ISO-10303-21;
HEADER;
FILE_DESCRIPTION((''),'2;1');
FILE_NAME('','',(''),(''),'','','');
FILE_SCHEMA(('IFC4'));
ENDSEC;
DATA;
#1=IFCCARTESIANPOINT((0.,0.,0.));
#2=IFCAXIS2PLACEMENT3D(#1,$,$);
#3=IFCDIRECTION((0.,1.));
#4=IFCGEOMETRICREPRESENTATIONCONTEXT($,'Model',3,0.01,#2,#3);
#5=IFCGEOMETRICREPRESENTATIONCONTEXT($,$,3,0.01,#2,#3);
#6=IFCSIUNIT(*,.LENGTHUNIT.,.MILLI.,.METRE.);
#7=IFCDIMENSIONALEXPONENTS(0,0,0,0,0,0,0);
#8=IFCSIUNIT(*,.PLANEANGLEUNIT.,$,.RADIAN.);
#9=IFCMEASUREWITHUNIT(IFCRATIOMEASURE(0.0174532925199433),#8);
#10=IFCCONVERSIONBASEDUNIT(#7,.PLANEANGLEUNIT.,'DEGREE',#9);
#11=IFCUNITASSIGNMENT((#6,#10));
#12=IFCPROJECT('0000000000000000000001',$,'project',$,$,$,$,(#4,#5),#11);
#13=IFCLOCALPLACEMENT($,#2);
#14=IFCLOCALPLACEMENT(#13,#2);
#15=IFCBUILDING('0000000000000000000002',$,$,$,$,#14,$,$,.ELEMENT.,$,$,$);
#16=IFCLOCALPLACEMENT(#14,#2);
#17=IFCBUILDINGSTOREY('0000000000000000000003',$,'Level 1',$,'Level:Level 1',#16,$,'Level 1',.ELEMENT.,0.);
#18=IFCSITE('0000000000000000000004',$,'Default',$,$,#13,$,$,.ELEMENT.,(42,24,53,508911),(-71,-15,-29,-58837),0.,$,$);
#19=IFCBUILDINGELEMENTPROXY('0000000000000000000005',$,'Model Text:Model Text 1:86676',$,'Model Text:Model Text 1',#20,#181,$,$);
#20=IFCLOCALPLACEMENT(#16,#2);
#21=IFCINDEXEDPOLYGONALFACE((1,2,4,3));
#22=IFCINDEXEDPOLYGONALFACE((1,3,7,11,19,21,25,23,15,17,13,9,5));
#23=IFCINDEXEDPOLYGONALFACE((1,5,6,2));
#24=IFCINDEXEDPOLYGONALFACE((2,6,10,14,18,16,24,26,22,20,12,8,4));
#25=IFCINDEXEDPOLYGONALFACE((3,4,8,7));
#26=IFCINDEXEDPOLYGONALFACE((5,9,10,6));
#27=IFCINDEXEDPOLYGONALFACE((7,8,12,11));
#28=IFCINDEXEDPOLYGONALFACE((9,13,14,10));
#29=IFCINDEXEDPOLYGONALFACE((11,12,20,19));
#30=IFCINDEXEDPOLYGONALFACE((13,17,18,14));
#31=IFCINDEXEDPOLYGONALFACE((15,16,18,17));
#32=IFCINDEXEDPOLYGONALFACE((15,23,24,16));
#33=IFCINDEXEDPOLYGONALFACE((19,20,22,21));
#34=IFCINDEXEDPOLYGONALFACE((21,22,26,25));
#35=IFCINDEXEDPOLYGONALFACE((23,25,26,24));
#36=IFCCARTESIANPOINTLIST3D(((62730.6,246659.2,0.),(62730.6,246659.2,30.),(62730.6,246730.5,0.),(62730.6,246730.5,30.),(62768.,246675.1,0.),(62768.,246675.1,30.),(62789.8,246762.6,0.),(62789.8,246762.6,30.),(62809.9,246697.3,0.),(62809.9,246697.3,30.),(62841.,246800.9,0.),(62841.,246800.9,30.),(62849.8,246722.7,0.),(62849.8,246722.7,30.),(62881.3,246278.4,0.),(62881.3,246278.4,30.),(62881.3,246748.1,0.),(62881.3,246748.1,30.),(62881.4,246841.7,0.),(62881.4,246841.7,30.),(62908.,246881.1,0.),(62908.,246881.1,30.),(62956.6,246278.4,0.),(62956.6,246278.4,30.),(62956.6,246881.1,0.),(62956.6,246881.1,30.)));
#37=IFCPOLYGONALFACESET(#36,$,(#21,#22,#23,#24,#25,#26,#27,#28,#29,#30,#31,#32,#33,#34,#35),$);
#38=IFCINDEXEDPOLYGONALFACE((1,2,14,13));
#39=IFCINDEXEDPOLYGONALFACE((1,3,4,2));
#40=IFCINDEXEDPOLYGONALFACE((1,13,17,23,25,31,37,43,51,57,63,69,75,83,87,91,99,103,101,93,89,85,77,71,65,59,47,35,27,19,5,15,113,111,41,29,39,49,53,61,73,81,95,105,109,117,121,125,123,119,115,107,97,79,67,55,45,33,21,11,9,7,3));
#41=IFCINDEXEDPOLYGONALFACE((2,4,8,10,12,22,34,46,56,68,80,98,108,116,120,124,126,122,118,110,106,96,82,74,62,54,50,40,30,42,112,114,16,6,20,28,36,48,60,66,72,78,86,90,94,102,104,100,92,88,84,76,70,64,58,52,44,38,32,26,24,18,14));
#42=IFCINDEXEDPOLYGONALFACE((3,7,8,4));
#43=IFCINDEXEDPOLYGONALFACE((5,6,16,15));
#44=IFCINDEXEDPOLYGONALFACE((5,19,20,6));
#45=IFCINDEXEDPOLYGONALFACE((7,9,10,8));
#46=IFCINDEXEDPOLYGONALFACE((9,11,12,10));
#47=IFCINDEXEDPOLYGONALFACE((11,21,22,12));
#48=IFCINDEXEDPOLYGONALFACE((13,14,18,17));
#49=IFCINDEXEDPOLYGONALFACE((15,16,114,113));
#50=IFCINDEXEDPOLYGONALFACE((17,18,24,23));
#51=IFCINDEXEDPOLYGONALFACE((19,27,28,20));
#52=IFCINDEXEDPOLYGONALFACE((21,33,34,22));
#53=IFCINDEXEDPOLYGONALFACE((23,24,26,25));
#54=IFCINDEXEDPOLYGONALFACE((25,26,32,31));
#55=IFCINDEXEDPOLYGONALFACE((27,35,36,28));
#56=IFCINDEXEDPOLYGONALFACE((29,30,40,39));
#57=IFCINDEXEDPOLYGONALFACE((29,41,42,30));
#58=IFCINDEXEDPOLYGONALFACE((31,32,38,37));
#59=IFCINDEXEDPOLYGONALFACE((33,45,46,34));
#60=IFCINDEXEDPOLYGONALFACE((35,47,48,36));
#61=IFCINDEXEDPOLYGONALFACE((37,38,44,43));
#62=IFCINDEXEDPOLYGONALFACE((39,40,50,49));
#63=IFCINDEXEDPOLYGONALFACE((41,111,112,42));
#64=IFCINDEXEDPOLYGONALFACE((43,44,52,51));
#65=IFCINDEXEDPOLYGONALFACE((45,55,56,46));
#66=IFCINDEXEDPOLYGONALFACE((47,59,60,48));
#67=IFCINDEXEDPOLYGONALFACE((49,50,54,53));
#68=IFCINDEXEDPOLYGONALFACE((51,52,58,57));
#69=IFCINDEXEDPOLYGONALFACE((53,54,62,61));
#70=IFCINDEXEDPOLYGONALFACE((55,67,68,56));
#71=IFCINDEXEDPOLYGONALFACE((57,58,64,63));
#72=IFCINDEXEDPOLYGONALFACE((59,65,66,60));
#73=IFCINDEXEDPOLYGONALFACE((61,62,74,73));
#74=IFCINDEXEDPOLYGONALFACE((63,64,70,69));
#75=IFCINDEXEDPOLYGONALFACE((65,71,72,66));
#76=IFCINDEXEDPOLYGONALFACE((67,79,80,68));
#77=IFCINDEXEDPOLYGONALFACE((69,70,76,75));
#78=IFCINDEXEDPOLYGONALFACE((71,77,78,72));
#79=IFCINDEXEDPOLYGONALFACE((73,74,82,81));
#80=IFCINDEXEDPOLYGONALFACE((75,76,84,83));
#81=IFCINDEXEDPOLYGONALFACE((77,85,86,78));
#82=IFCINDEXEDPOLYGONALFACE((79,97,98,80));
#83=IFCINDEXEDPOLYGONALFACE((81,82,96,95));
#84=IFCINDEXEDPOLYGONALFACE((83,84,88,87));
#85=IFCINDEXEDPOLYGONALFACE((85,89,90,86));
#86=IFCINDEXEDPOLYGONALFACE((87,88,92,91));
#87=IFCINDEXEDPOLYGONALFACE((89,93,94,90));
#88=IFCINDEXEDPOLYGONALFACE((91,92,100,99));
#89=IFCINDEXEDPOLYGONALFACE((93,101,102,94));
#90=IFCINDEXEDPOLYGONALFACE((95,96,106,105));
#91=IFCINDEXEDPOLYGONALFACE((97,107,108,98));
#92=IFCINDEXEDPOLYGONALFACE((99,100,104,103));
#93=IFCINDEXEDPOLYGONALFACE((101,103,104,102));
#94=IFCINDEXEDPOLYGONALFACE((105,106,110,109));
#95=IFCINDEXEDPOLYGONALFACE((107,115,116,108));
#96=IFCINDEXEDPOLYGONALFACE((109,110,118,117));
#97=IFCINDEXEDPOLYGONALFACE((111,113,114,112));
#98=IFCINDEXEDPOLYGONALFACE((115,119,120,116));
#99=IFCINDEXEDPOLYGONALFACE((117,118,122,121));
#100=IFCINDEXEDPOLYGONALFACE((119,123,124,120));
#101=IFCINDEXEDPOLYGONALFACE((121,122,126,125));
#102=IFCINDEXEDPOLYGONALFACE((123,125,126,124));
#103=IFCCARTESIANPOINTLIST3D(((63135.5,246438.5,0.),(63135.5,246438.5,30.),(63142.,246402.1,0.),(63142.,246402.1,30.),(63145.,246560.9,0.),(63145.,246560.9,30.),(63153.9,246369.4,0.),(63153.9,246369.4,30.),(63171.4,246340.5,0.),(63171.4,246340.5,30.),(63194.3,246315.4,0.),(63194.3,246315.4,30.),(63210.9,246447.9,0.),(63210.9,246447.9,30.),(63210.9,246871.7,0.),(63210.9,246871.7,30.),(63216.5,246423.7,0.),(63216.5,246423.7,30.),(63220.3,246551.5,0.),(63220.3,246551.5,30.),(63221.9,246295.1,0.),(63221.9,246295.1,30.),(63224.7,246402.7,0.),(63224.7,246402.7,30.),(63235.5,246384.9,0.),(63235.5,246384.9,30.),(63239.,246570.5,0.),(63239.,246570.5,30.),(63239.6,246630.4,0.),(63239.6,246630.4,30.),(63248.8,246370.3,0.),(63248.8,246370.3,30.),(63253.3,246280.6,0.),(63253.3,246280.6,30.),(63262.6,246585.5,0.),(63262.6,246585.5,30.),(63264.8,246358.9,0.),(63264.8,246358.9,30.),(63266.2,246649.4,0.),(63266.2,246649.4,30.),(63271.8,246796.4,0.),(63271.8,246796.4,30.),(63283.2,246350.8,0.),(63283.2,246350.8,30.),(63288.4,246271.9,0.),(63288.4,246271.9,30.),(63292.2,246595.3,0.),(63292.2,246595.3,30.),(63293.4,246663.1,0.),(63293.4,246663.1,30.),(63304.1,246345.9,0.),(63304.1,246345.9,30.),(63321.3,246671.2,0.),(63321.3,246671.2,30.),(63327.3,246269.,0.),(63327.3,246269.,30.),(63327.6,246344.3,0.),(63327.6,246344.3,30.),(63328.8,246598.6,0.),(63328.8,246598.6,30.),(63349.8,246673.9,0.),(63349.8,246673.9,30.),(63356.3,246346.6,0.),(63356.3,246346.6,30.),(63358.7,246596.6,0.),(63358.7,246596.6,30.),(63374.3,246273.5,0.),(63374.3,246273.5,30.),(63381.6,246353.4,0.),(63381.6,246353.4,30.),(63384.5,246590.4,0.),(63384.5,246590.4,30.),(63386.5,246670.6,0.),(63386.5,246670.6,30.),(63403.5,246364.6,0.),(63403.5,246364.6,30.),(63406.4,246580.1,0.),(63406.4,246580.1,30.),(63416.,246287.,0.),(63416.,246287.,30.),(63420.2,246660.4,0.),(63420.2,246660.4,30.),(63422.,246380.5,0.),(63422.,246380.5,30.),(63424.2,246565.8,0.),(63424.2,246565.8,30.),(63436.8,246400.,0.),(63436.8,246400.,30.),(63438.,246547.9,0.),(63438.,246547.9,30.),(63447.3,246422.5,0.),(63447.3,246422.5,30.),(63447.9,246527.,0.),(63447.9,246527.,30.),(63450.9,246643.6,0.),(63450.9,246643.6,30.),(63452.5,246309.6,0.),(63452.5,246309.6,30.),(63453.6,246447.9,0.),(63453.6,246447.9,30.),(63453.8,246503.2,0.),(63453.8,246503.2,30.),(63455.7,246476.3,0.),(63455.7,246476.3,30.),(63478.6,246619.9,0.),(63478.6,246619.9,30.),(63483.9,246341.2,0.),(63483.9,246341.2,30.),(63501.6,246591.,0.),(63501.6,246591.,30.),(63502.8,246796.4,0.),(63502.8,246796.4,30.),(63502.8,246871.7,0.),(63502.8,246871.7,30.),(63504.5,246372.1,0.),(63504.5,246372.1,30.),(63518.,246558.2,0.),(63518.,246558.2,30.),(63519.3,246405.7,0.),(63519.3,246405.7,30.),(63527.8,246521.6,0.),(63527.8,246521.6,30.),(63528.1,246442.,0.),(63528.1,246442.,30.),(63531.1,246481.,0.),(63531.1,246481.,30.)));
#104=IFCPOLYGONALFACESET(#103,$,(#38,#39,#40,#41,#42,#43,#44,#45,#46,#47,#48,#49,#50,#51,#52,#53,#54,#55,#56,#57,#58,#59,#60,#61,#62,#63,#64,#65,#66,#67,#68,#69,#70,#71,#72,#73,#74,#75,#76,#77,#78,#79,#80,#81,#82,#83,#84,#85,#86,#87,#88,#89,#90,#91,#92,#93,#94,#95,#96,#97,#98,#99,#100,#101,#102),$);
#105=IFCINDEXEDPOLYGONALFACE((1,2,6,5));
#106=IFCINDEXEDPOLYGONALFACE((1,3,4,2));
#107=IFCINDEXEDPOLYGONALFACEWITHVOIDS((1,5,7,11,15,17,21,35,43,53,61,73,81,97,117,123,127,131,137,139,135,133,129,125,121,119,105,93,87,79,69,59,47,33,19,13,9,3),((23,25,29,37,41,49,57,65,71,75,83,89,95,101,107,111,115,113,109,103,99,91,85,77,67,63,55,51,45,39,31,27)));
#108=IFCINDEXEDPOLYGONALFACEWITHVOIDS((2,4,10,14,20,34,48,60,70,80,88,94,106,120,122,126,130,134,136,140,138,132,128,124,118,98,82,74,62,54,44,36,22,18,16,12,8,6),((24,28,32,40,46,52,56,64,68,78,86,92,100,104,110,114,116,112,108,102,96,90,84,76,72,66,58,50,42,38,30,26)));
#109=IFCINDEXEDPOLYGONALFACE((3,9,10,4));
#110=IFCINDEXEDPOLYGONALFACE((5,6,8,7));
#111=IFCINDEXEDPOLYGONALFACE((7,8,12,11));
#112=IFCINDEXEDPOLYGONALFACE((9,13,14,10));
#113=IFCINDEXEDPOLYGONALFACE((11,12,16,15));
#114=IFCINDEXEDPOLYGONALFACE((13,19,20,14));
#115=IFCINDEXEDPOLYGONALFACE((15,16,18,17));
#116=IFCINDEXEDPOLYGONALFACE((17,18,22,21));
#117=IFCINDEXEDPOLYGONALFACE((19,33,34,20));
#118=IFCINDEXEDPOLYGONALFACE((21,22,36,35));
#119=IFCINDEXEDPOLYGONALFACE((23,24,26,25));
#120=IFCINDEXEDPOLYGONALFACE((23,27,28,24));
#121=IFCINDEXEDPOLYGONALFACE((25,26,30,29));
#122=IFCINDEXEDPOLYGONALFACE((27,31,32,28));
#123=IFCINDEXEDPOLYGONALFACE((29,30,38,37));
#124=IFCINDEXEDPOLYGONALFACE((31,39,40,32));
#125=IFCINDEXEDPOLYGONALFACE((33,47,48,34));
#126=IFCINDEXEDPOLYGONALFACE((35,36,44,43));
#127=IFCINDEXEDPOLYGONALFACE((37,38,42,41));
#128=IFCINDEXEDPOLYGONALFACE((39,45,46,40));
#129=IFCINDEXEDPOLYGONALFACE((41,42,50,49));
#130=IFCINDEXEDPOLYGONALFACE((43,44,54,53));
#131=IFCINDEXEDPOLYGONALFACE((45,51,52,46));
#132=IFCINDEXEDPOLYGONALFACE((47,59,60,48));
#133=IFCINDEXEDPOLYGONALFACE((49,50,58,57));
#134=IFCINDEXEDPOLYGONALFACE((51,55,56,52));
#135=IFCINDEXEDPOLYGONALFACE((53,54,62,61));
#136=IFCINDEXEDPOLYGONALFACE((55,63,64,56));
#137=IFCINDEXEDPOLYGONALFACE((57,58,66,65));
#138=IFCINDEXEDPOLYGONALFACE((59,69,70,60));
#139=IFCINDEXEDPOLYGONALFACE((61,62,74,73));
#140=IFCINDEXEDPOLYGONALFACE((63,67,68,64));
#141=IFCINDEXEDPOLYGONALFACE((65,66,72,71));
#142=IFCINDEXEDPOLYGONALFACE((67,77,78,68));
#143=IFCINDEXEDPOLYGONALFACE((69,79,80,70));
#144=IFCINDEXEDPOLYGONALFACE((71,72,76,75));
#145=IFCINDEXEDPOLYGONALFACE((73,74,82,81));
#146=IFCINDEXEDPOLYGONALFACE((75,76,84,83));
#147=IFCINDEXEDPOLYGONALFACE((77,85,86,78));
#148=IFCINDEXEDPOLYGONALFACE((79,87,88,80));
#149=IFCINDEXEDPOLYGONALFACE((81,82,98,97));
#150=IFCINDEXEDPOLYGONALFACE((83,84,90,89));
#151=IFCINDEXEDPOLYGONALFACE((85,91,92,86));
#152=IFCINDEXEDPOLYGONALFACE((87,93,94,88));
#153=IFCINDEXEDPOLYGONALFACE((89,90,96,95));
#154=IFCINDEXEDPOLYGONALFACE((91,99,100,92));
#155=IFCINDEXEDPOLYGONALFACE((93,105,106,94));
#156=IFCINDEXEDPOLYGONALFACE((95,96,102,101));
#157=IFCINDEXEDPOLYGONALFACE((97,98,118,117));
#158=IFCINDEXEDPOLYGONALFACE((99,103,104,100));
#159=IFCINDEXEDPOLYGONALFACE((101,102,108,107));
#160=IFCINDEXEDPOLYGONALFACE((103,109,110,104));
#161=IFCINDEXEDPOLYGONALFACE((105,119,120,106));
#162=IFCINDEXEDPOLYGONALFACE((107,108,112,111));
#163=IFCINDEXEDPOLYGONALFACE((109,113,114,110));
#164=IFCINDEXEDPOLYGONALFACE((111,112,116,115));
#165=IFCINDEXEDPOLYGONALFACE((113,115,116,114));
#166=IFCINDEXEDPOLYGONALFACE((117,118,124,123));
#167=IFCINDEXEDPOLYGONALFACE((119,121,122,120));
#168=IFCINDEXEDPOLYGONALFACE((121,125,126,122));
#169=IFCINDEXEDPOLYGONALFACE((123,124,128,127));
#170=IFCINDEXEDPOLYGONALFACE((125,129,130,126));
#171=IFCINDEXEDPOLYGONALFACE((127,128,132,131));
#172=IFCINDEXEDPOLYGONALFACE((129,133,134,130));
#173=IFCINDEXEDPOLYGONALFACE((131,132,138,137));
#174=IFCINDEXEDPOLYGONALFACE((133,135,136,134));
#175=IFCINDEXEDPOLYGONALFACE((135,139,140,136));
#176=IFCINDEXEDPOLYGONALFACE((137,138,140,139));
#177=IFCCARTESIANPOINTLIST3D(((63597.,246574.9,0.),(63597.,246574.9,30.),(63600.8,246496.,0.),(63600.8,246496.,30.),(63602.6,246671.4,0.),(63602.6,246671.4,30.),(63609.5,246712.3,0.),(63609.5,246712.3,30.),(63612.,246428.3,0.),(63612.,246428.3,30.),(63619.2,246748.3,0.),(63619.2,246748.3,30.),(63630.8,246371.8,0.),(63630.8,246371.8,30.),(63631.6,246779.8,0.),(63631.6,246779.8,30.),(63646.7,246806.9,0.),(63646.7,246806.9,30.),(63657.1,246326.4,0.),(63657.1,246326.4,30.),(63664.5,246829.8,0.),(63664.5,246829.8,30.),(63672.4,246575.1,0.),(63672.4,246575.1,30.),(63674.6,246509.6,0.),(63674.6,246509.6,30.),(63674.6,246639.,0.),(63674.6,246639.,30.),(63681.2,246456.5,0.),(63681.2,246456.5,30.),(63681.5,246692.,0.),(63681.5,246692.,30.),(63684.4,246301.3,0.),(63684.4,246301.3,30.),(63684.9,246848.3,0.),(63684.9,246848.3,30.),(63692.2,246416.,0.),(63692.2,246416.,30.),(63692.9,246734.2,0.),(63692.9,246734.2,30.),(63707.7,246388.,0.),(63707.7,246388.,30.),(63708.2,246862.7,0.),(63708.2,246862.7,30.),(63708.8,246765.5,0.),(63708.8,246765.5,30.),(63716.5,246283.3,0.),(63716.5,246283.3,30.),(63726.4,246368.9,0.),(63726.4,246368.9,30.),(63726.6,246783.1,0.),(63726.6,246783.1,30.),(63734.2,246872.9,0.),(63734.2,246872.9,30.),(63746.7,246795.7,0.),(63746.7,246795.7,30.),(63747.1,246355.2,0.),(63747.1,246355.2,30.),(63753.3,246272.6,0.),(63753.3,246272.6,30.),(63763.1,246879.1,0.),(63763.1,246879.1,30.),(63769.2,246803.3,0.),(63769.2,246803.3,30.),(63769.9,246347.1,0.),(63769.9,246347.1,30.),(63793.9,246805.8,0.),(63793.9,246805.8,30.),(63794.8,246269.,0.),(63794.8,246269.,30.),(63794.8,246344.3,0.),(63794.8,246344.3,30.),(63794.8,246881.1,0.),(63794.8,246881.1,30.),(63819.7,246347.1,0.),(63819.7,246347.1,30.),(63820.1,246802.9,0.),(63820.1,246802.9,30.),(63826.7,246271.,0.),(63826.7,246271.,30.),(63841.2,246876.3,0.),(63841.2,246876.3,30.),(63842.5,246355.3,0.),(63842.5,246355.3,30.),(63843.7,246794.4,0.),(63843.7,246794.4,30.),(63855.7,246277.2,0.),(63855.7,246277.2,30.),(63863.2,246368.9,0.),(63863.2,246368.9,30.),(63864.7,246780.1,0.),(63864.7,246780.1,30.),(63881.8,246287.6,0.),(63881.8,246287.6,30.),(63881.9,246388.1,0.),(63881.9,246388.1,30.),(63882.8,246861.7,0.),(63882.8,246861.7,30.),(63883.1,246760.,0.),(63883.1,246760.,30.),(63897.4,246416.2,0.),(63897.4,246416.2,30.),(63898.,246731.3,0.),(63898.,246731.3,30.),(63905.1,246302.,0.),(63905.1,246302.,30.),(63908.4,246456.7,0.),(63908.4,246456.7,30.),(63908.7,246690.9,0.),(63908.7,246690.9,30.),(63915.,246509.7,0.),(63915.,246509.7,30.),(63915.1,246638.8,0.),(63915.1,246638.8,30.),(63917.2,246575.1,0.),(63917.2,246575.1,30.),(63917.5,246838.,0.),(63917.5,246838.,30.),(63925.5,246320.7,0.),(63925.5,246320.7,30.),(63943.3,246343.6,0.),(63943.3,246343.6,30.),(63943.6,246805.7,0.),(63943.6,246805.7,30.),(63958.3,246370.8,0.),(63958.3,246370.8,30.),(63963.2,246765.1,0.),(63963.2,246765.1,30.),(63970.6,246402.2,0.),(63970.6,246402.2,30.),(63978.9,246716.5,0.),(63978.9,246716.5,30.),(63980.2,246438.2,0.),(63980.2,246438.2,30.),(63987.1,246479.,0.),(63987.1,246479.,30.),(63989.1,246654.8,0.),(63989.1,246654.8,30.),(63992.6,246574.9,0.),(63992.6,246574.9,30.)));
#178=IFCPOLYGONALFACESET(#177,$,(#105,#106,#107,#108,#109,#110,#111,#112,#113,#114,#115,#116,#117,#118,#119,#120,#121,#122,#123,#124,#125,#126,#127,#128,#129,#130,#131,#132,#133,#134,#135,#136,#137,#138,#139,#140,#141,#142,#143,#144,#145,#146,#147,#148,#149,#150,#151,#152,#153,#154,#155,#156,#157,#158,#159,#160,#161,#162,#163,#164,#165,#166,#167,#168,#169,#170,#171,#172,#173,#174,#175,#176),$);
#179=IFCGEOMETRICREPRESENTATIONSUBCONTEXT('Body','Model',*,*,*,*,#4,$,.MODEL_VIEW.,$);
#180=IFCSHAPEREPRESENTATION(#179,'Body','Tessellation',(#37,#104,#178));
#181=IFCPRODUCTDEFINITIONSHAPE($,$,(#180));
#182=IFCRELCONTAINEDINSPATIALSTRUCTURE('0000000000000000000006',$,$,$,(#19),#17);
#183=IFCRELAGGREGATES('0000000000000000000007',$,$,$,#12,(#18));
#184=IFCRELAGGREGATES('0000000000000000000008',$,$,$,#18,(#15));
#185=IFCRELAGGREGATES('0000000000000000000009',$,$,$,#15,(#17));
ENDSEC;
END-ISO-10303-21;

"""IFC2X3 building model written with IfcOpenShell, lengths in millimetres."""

from ifc_helpers import new_model, entity, si_unit, converted_unit, direction, frame, origin, place, context, subcontext, project, spatial, polyline, outline, extrude, element, save


model = new_model("IFC2X3")

# Units and contexts
model_context = context("Model", 3, precision=0.01, world=origin(), true_north=direction((0.0, 1.0)))
context_of_model = context(None, 3, precision=0.01, world=origin(), true_north=direction((0.0, 1.0)))
body_context = subcontext(model_context, "Body", "Model", "MODEL_VIEW")
ifc_project = project(units=[si_unit("LENGTHUNIT", "METRE", prefix="MILLI"), converted_unit("PLANEANGLEUNIT", "DEGREE", entity("IfcRatioMeasure", 0.0174532925199433), si_unit("PLANEANGLEUNIT", "RADIAN"), dimensions=[0, 0, 0, 0, 0, 0, 0])], contexts=[model_context, context_of_model])

# Site, building, storey
site_placement = place(None, origin())
site = spatial("IfcSite", under=ifc_project, at=site_placement, Name="Default", CompositionType="ELEMENT", RefLatitude=(42, 24, 53, 508911), RefLongitude=(-71, -15, -29, -58837), RefElevation=0.0)
building_placement = place(site_placement, origin())
building = spatial("IfcBuilding", under=site, at=building_placement, CompositionType="ELEMENT")
storey_placement = place(building_placement, origin())
storey = spatial("IfcBuildingStorey", under=building, at=storey_placement, Name="Level 1", ObjectType="Level:Level 1", LongName="Level 1", CompositionType="ELEMENT", Elevation=0.0)

# Building element proxy
proxy_1_placement = place(storey_placement, origin())
element("IfcBuildingElementProxy", 1, at=proxy_1_placement, inside=storey, Name="Model Text:Model Text 1:86676", ObjectType="Model Text:Model Text 1", context=body_context, shape_type="SweptSolid", body=[
    extrude(outline(polyline([(-410.6, -111.6), (192.1, -111.6), (192.1, -63.1), (152.7, -36.4), (111.9, 4.0), (73.6, 55.2), (41.4, 114.4), (-29.8, 114.4), (-13.9, 77.0), (8.3, 35.1), (33.7, -4.8), (59.1, -36.3), (-410.6, -36.3), (-410.6, -111.6)])), frame((62845.0, 246689.0, 0.0), z_axis=(0.0, 0.0, 1.0), x_axis=(0.0, 1.0, 0.0)), (0.0, 0.0, 1.0), 30.0),
    extrude(outline(polyline([(12.1, -219.3), (49.1, -219.3), (83.4, -213.2), (114.8, -201.1), (143.5, -182.8), (168.3, -159.2), (188.1, -130.8), (202.8, -97.8), (212.4, -60.0), (216.1, -12.9), (210.0, 30.5), (194.1, 70.4), (168.4, 106.8), (141.6, 132.5), (111.1, 152.9), (76.9, 167.9), (39.0, 177.6), (-1.5, 181.4), (-39.3, 178.1), (-74.4, 167.6), (-106.9, 150.1), (-135.0, 126.9), (-157.0, 99.6), (-172.8, 68.1), (-182.5, 32.6), (-184.8, 4.0), (-181.6, -24.8), (-172.9, -54.0), (-158.8, -83.5), (-316.6, -22.9), (-276.5, 204.6), (-350.7, 217.7), (-401.4, -69.8), (-106.8, -188.8), (-84.5, -116.2), (-99.9, -94.5), (-110.6, -68.6), (-115.1, -37.8), (-112.0, -1.2), (-104.8, 27.9), (-94.2, 52.3), (-80.3, 72.0), (-63.1, 87.0), (-43.0, 97.5), (-20.8, 103.6), (3.8, 105.3), (30.5, 102.6), (58.1, 95.6), (82.1, 84.9), (102.4, 70.6), (119.1, 52.7), (131.4, 31.7), (138.7, 8.2), (141.0, -17.9), (138.2, -46.6), (132.6, -69.4), (124.1, -89.2), (112.9, -105.9), (99.0, -119.6), (82.3, -130.2), (62.9, -137.7), (40.8, -142.2), (15.9, -143.5), (12.1, -219.3)])), frame((63349.4, 246488.6, 0.0), z_axis=(0.0, 0.0, 1.0), x_axis=(0.173842, -0.984774, 0.0)), (0.0, 0.0, 1.0), 30.0),
    extrude(outline(polyline([(-10.6, -198.7), (68.3, -198.7), (136.5, -190.7), (193.9, -174.7), (240.5, -150.6), (266.9, -124.4), (286.3, -93.2), (298.8, -57.0), (304.3, -15.7), (303.8, 16.2), (299.0, 45.5), (289.9, 72.1), (276.6, 96.0), (258.9, 117.3), (236.9, 136.2), (210.4, 152.5), (179.6, 166.3), (144.1, 177.6), (103.7, 186.3), (8.2, 196.4), (-71.8, 196.7), (-134.0, 189.4), (-183.3, 176.1), (-224.7, 158.4), (-258.2, 133.9), (-283.5, 100.3), (-300.1, 59.5), (-307.1, 13.4), (-306.6, -18.4), (-301.8, -47.5), (-292.8, -74.0), (-279.6, -97.9), (-262.0, -119.2), (-240.0, -138.1), (-213.6, -154.5), (-182.8, -168.4), (-147.3, -179.8), (-106.7, -188.6), (-10.6, -198.7)]), holes=[polyline([(-7.2, -123.5), (-71.0, -118.2), (-123.6, -108.8), (-165.2, -95.4), (-195.7, -78.0), (-212.4, -59.4), (-224.1, -38.7), (-230.6, -15.9), (-231.9, 8.9), (-227.8, 35.0), (-218.1, 58.1), (-202.8, 78.4), (-182.0, 95.8), (-152.6, 109.4), (-111.7, 118.1), (-59.4, 122.0), (4.4, 121.1), (69.6, 115.8), (122.2, 106.7), (162.2, 93.7), (189.5, 77.0), (207.7, 57.4), (220.4, 36.0), (227.5, 12.8), (229.1, -12.1), (225.2, -36.8), (215.9, -59.2), (201.3, -79.3), (181.4, -97.1), (152.6, -111.2), (111.6, -120.3), (58.3, -124.4), (-7.2, -123.5)])]), frame((63796.0, 246573.7, 0.0), z_axis=(0.0, 0.0, 1.0), x_axis=(0.047515, -0.998871, 0.0)), (0.0, 0.0, 1.0), 30.0),
])

save(model, "model.ifc")
